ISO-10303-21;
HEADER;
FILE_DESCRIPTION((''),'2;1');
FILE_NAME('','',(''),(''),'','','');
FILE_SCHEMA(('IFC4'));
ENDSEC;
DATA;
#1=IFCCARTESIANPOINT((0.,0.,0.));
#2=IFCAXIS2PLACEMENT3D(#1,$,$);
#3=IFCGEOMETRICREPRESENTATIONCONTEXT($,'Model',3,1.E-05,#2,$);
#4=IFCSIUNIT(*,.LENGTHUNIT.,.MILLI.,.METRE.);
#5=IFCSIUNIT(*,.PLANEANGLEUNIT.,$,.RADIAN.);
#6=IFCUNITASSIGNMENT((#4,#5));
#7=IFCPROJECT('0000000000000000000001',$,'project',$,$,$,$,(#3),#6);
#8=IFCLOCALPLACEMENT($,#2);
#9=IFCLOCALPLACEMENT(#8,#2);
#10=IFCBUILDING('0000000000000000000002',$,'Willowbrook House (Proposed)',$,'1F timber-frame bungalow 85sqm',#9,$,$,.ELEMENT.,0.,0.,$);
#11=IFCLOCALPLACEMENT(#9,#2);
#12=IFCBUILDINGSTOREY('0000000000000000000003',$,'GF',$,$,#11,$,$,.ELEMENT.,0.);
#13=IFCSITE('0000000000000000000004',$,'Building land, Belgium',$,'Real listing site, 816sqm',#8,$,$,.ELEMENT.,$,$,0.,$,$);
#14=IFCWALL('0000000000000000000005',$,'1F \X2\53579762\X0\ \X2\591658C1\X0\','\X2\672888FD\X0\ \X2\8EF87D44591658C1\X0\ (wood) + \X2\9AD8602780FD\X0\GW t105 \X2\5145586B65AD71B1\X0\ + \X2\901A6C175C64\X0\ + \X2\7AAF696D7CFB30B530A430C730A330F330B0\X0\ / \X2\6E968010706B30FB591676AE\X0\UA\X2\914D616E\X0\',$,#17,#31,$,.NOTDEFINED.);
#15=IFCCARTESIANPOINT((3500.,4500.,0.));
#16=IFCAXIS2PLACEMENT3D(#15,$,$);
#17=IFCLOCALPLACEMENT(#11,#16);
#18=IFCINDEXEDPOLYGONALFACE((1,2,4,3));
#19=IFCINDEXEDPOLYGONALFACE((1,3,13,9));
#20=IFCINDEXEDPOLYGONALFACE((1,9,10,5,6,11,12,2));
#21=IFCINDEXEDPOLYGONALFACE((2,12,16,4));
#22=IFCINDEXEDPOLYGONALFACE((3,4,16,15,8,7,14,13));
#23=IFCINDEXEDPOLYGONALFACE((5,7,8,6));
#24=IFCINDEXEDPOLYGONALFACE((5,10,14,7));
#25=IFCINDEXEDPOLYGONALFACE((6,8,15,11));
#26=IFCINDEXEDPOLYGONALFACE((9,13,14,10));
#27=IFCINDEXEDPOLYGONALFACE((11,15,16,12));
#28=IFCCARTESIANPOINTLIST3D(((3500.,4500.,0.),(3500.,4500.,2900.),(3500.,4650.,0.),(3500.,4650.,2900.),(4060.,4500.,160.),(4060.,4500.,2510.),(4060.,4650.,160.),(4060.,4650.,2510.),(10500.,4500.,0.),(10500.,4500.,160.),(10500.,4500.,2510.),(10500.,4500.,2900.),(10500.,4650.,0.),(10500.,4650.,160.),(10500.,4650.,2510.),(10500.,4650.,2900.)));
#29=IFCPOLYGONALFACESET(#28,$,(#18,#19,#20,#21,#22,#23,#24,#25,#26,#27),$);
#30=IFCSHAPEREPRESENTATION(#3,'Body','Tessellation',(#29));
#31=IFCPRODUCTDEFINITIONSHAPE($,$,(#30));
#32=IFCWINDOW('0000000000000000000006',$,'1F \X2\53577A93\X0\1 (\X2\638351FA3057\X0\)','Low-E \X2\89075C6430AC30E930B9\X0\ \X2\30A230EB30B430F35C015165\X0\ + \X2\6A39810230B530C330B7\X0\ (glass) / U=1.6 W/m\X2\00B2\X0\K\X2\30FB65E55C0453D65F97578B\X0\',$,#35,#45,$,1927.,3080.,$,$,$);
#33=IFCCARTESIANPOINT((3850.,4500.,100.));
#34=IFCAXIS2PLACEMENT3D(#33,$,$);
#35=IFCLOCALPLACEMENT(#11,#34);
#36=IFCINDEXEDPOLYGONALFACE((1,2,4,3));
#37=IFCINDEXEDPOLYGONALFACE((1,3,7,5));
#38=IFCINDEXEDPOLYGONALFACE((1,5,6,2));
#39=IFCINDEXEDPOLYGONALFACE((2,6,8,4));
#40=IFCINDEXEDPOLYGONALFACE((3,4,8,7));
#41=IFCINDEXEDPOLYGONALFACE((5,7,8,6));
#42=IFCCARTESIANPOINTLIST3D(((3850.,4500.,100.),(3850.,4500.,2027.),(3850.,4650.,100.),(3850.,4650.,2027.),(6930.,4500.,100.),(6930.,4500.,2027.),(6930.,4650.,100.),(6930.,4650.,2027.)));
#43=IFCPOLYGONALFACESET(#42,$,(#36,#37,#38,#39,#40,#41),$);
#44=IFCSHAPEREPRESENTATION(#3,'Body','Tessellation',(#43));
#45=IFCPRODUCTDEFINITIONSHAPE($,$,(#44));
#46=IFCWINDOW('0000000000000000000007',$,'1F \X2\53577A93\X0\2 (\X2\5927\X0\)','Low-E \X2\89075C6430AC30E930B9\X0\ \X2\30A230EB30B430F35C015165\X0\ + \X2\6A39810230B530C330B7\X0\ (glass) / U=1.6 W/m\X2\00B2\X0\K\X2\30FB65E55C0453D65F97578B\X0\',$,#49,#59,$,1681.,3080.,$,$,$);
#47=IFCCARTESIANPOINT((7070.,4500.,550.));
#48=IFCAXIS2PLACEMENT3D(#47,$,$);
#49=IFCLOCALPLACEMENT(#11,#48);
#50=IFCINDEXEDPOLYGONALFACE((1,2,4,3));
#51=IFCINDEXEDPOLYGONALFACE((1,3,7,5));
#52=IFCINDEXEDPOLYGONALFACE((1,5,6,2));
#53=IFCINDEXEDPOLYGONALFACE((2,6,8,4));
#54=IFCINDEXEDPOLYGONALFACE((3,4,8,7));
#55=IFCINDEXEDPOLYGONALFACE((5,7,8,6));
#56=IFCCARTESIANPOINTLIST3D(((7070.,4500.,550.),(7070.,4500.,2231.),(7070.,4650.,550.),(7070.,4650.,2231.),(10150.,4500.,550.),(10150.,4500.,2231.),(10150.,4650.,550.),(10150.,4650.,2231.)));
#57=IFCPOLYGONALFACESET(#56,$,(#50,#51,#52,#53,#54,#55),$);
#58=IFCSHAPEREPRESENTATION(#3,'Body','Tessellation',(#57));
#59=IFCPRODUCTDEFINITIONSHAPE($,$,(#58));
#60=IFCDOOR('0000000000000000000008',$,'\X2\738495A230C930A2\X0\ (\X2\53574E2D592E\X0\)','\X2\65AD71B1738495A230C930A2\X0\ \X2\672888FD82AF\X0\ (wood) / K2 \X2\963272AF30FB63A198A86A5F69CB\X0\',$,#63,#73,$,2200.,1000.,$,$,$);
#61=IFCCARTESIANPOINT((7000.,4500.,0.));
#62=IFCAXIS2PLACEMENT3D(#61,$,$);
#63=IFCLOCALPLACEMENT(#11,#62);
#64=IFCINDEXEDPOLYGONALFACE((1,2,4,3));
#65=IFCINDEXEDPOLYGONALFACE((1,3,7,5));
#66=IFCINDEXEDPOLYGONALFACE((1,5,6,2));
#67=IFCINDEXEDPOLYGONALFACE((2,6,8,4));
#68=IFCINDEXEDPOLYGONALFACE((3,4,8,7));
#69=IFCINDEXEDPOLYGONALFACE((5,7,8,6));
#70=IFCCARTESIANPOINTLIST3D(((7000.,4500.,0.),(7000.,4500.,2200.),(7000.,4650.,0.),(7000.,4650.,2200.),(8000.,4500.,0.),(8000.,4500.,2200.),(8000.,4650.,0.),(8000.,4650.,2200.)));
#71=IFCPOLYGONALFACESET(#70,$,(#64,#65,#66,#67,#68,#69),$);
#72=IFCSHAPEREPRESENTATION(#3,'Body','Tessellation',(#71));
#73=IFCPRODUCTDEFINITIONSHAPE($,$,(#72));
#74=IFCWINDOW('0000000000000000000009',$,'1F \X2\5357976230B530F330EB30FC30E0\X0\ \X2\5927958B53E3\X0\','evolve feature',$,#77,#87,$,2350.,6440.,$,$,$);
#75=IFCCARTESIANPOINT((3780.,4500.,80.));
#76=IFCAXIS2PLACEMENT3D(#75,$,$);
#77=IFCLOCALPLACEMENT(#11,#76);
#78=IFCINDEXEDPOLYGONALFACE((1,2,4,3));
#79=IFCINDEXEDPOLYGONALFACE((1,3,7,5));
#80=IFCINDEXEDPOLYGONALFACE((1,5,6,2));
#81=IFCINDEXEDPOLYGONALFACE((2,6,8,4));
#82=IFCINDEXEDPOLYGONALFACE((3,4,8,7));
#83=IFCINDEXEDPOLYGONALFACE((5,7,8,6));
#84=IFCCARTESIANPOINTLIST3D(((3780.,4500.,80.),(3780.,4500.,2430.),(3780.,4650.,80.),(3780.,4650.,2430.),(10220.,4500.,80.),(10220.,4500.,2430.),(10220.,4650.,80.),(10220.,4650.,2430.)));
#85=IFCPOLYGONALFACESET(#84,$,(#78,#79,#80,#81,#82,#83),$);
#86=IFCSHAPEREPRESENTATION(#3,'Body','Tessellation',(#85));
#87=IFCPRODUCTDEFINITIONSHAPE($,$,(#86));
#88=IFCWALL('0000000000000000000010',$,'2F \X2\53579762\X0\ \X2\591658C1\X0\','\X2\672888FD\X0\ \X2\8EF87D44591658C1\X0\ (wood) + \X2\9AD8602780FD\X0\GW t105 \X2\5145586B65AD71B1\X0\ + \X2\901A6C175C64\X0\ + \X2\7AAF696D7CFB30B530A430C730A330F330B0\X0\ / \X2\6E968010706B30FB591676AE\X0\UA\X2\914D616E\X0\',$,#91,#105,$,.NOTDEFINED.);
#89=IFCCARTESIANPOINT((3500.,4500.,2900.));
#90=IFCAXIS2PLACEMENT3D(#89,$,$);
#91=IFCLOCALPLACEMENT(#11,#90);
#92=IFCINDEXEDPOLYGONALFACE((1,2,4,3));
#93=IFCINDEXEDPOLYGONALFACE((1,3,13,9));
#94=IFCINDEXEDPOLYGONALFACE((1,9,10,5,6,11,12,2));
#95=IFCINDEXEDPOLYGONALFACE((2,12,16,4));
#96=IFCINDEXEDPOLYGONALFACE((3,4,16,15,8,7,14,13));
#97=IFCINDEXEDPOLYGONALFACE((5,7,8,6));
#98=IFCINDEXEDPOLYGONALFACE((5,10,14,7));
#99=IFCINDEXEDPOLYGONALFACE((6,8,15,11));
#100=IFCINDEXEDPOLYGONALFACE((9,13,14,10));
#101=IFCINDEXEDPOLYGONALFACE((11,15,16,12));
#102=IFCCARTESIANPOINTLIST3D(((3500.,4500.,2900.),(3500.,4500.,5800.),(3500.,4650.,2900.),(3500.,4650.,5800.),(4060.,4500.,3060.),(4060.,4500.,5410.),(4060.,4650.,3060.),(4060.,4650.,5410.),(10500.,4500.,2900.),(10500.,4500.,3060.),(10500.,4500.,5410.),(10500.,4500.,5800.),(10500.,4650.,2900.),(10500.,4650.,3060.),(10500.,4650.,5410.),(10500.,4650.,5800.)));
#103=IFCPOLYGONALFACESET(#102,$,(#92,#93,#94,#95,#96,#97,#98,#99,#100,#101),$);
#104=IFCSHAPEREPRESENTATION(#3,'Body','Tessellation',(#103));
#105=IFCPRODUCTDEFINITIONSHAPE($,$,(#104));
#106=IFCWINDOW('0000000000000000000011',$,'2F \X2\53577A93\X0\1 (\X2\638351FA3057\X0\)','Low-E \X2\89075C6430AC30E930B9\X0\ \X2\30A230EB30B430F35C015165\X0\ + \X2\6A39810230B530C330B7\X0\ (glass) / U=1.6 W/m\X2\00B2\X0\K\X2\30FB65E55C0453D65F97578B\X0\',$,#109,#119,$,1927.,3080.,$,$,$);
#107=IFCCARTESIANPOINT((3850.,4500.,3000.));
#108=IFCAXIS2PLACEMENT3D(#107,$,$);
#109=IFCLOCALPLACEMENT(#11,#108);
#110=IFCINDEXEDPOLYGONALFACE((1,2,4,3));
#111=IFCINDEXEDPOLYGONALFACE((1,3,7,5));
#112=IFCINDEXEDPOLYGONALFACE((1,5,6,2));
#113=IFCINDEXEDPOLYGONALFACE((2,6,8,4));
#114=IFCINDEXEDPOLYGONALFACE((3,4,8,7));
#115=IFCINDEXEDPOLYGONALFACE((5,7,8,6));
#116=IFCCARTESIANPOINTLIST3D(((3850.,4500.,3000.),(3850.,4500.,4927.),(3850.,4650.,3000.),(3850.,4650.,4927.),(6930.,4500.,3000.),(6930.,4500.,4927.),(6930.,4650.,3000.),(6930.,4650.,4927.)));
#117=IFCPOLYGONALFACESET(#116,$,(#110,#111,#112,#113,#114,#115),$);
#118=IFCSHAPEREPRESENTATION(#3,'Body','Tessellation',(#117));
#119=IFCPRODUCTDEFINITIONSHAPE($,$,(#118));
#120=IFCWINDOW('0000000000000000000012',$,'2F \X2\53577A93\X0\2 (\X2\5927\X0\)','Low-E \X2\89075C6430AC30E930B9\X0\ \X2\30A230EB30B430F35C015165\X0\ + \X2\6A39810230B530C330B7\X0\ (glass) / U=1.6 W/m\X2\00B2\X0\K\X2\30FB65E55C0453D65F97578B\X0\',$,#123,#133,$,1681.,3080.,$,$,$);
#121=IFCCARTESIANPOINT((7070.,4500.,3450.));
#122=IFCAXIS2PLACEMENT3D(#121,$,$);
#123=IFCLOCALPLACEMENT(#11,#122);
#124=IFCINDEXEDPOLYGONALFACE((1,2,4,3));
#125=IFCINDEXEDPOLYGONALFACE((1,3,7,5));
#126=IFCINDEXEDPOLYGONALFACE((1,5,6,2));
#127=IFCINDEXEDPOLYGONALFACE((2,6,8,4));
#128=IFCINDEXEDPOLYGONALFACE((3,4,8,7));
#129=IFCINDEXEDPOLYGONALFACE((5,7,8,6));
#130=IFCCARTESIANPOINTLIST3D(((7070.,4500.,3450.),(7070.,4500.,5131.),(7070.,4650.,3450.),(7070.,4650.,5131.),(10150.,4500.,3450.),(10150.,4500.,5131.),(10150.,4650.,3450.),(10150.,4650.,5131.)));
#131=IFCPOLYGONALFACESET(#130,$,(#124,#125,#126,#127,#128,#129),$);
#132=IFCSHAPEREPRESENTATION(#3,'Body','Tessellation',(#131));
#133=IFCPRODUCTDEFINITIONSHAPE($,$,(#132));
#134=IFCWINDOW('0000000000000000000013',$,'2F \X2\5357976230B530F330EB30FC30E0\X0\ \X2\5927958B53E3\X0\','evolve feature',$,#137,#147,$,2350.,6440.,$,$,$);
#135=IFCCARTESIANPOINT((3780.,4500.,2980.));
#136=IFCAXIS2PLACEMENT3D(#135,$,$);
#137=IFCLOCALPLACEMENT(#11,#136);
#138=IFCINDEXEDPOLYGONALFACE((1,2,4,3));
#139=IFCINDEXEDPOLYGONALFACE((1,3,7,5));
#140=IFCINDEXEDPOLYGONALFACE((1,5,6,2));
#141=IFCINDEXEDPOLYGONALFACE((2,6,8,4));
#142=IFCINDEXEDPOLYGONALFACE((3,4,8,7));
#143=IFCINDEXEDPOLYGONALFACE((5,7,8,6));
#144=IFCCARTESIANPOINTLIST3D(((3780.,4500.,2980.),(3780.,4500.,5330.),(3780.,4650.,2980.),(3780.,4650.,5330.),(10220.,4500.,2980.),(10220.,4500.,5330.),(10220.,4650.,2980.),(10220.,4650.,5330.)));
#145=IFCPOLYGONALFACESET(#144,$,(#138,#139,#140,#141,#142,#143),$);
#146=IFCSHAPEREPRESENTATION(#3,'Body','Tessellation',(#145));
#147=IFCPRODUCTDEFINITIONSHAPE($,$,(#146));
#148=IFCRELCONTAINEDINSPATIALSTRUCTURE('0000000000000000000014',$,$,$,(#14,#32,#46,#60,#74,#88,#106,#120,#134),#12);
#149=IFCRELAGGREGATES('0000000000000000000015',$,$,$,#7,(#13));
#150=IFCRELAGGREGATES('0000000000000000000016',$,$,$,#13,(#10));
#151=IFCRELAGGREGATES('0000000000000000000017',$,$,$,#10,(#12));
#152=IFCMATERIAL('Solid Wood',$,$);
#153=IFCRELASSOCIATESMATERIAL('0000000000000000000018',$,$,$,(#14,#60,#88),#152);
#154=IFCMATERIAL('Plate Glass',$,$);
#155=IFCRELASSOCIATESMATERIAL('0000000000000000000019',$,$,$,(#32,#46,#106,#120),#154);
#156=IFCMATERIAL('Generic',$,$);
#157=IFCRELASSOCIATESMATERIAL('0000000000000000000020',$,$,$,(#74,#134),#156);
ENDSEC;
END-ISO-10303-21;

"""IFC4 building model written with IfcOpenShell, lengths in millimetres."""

from ifc_helpers import new_model, si_unit, frame, frame_2d, origin, place, context, project, spatial, rectangle, extrude, material, element, fill, save


model = new_model("IFC4")

# Units and contexts
model_context = context("Model", 3, precision=1e-05, world=origin())
ifc_project = project(units=[si_unit("LENGTHUNIT", "METRE", prefix="MILLI"), si_unit("PLANEANGLEUNIT", "RADIAN")], contexts=[model_context])

# Site, building, storey
site_placement = place(None, origin())
site = spatial("IfcSite", under=ifc_project, at=site_placement, Name="Building land, Belgium", ObjectType="Real listing site, 816sqm", CompositionType="ELEMENT", RefElevation=0.0)
building_placement = place(site_placement, origin())
building = spatial("IfcBuilding", under=site, at=building_placement, Name="Willowbrook House (Proposed)", ObjectType="1F timber-frame bungalow 85sqm", CompositionType="ELEMENT", ElevationOfRefHeight=0.0, ElevationOfTerrain=0.0)
storey_placement = place(building_placement, origin())
storey = spatial("IfcBuildingStorey", under=building, at=storey_placement, Name="GF", CompositionType="ELEMENT", Elevation=0.0)

# Shared definitions
ifc_material_1 = material(Name="Solid Wood")
ifc_material_2 = material(Name="Generic")

# Wall, openings, windows, door
wall_1_placement = place(storey_placement, frame((3500.0, 4500.0, 0.0)))
wall_1 = element("IfcWall", 1, at=wall_1_placement, inside=storey, material=ifc_material_1, Name="1F 南面 外壁", Description="木製 軸組外壁 (wood) + 高性能GW t105 充填断熱 + 通気層 + 窯業系サイディング / 準耐火・外皮UA配慮", PredefinedType="NOTDEFINED", context=model_context, shape_type="SweptSolid", body=[
    extrude(rectangle(XDim=7000.0, YDim=150.0, at=frame_2d((3500.0, 75.0))), frame((3500.0, 4500.0, 0.0)), (0.0, 0.0, 1.0), 2900.0),
])
opening_1_placement = place(storey_placement, frame((3850.0, 4500.0, 100.0)))
opening_1 = element("IfcOpeningElement", 2, at=opening_1_placement, cuts=wall_1, PredefinedType="NOTDEFINED", context=model_context, shape_type="SweptSolid", body=[
    extrude(rectangle(XDim=3080.0, YDim=150.0, at=frame_2d((1540.0, 75.0))), frame((3850.0, 4500.0, 100.0)), (0.0, 0.0, 1.0), 1927.0),
])
opening_2_placement = place(storey_placement, frame((7070.0, 4500.0, 550.0)))
opening_2 = element("IfcOpeningElement", 3, at=opening_2_placement, cuts=wall_1, PredefinedType="NOTDEFINED", context=model_context, shape_type="SweptSolid", body=[
    extrude(rectangle(XDim=3080.0, YDim=150.0, at=frame_2d((1540.0, 75.0))), frame((7070.0, 4500.0, 550.0)), (0.0, 0.0, 1.0), 1681.0),
])
opening_3_placement = place(storey_placement, frame((7000.0, 4500.0, 0.0)))
opening_3 = element("IfcOpeningElement", 4, at=opening_3_placement, cuts=wall_1, PredefinedType="NOTDEFINED", context=model_context, shape_type="SweptSolid", body=[
    extrude(rectangle(XDim=1000.0, YDim=150.0, at=frame_2d((500.0, 75.0))), frame((7000.0, 4500.0, 0.0)), (0.0, 0.0, 1.0), 2200.0),
])
opening_4_placement = place(storey_placement, frame((3780.0, 4500.0, 80.0)))
opening_4 = element("IfcOpeningElement", 5, at=opening_4_placement, cuts=wall_1, PredefinedType="NOTDEFINED", context=model_context, shape_type="SweptSolid", body=[
    extrude(rectangle(XDim=6440.0, YDim=150.0, at=frame_2d((3220.0, 75.0))), frame((3780.0, 4500.0, 80.0)), (0.0, 0.0, 1.0), 2350.0),
])
ifc_material_3 = material(Name="Plate Glass")
window_1_placement = place(storey_placement, frame((3850.0, 4500.0, 100.0)))
window_1 = element("IfcWindow", 6, at=window_1_placement, inside=storey, material=ifc_material_3, Name="1F 南窓1 (掃出し)", Description="Low-E 複層ガラス アルゴン封入 + 樹脂サッシ (glass) / U=1.6 W/m²K・日射取得型", OverallHeight=1927.0, OverallWidth=3080.0, context=model_context, shape_type="SweptSolid", body=[
    extrude(rectangle(XDim=3080.0, YDim=150.0, at=frame_2d((1540.0, 75.0))), frame((3850.0, 4500.0, 100.0)), (0.0, 0.0, 1.0), 1927.0),
])
fill(opening_1, window_1)
window_2_placement = place(storey_placement, frame((7070.0, 4500.0, 550.0)))
window_2 = element("IfcWindow", 7, at=window_2_placement, inside=storey, material=ifc_material_3, Name="1F 南窓2 (大)", Description="Low-E 複層ガラス アルゴン封入 + 樹脂サッシ (glass) / U=1.6 W/m²K・日射取得型", OverallHeight=1681.0, OverallWidth=3080.0, context=model_context, shape_type="SweptSolid", body=[
    extrude(rectangle(XDim=3080.0, YDim=150.0, at=frame_2d((1540.0, 75.0))), frame((7070.0, 4500.0, 550.0)), (0.0, 0.0, 1.0), 1681.0),
])
fill(opening_2, window_2)
door_placement = place(storey_placement, frame((7000.0, 4500.0, 0.0)))
door = element("IfcDoor", 8, at=door_placement, inside=storey, material=ifc_material_1, Name="玄関ドア (南中央)", Description="断熱玄関ドア 木製芯 (wood) / K2 防犯・採風機構", OverallHeight=2200.0, OverallWidth=1000.0, context=model_context, shape_type="SweptSolid", body=[
    extrude(rectangle(XDim=1000.0, YDim=150.0, at=frame_2d((500.0, 75.0))), frame((7000.0, 4500.0, 0.0)), (0.0, 0.0, 1.0), 2200.0),
])
fill(opening_3, door)
window_3_placement = place(storey_placement, frame((3780.0, 4500.0, 80.0)))
window_3 = element("IfcWindow", 9, at=window_3_placement, inside=storey, material=ifc_material_2, Name="1F 南面サンルーム 大開口", Description="evolve feature", OverallHeight=2350.0, OverallWidth=6440.0, context=model_context, shape_type="SweptSolid", body=[
    extrude(rectangle(XDim=6440.0, YDim=150.0, at=frame_2d((3220.0, 75.0))), frame((3780.0, 4500.0, 80.0)), (0.0, 0.0, 1.0), 2350.0),
])
fill(opening_4, window_3)

# Wall, openings, windows
wall_2_placement = place(storey_placement, frame((3500.0, 4500.0, 2900.0)))
wall_2 = element("IfcWall", 10, at=wall_2_placement, inside=storey, material=ifc_material_1, Name="2F 南面 外壁", Description="木製 軸組外壁 (wood) + 高性能GW t105 充填断熱 + 通気層 + 窯業系サイディング / 準耐火・外皮UA配慮", PredefinedType="NOTDEFINED", context=model_context, shape_type="SweptSolid", body=[
    extrude(rectangle(XDim=7000.0, YDim=150.0, at=frame_2d((3500.0, 75.0))), frame((3500.0, 4500.0, 2900.0)), (0.0, 0.0, 1.0), 2900.0),
])
opening_5_placement = place(storey_placement, frame((3850.0, 4500.0, 3000.0)))
opening_5 = element("IfcOpeningElement", 11, at=opening_5_placement, cuts=wall_2, PredefinedType="NOTDEFINED", context=model_context, shape_type="SweptSolid", body=[
    extrude(rectangle(XDim=3080.0, YDim=150.0, at=frame_2d((1540.0, 75.0))), frame((3850.0, 4500.0, 3000.0)), (0.0, 0.0, 1.0), 1927.0),
])
opening_6_placement = place(storey_placement, frame((7070.0, 4500.0, 3450.0)))
opening_6 = element("IfcOpeningElement", 12, at=opening_6_placement, cuts=wall_2, PredefinedType="NOTDEFINED", context=model_context, shape_type="SweptSolid", body=[
    extrude(rectangle(XDim=3080.0, YDim=150.0, at=frame_2d((1540.0, 75.0))), frame((7070.0, 4500.0, 3450.0)), (0.0, 0.0, 1.0), 1681.0),
])
opening_7_placement = place(storey_placement, frame((3780.0, 4500.0, 2980.0)))
opening_7 = element("IfcOpeningElement", 13, at=opening_7_placement, cuts=wall_2, PredefinedType="NOTDEFINED", context=model_context, shape_type="SweptSolid", body=[
    extrude(rectangle(XDim=6440.0, YDim=150.0, at=frame_2d((3220.0, 75.0))), frame((3780.0, 4500.0, 2980.0)), (0.0, 0.0, 1.0), 2350.0),
])
window_4_placement = place(storey_placement, frame((3850.0, 4500.0, 3000.0)))
window_4 = element("IfcWindow", 14, at=window_4_placement, inside=storey, material=ifc_material_3, Name="2F 南窓1 (掃出し)", Description="Low-E 複層ガラス アルゴン封入 + 樹脂サッシ (glass) / U=1.6 W/m²K・日射取得型", OverallHeight=1927.0, OverallWidth=3080.0, context=model_context, shape_type="SweptSolid", body=[
    extrude(rectangle(XDim=3080.0, YDim=150.0, at=frame_2d((1540.0, 75.0))), frame((3850.0, 4500.0, 3000.0)), (0.0, 0.0, 1.0), 1927.0),
])
fill(opening_5, window_4)
window_5_placement = place(storey_placement, frame((7070.0, 4500.0, 3450.0)))
window_5 = element("IfcWindow", 15, at=window_5_placement, inside=storey, material=ifc_material_3, Name="2F 南窓2 (大)", Description="Low-E 複層ガラス アルゴン封入 + 樹脂サッシ (glass) / U=1.6 W/m²K・日射取得型", OverallHeight=1681.0, OverallWidth=3080.0, context=model_context, shape_type="SweptSolid", body=[
    extrude(rectangle(XDim=3080.0, YDim=150.0, at=frame_2d((1540.0, 75.0))), frame((7070.0, 4500.0, 3450.0)), (0.0, 0.0, 1.0), 1681.0),
])
fill(opening_6, window_5)
window_6_placement = place(storey_placement, frame((3780.0, 4500.0, 2980.0)))
window_6 = element("IfcWindow", 16, at=window_6_placement, inside=storey, material=ifc_material_2, Name="2F 南面サンルーム 大開口", Description="evolve feature", OverallHeight=2350.0, OverallWidth=6440.0, context=model_context, shape_type="SweptSolid", body=[
    extrude(rectangle(XDim=6440.0, YDim=150.0, at=frame_2d((3220.0, 75.0))), frame((3780.0, 4500.0, 2980.0)), (0.0, 0.0, 1.0), 2350.0),
])
fill(opening_7, window_6)

save(model, "model.ifc")
